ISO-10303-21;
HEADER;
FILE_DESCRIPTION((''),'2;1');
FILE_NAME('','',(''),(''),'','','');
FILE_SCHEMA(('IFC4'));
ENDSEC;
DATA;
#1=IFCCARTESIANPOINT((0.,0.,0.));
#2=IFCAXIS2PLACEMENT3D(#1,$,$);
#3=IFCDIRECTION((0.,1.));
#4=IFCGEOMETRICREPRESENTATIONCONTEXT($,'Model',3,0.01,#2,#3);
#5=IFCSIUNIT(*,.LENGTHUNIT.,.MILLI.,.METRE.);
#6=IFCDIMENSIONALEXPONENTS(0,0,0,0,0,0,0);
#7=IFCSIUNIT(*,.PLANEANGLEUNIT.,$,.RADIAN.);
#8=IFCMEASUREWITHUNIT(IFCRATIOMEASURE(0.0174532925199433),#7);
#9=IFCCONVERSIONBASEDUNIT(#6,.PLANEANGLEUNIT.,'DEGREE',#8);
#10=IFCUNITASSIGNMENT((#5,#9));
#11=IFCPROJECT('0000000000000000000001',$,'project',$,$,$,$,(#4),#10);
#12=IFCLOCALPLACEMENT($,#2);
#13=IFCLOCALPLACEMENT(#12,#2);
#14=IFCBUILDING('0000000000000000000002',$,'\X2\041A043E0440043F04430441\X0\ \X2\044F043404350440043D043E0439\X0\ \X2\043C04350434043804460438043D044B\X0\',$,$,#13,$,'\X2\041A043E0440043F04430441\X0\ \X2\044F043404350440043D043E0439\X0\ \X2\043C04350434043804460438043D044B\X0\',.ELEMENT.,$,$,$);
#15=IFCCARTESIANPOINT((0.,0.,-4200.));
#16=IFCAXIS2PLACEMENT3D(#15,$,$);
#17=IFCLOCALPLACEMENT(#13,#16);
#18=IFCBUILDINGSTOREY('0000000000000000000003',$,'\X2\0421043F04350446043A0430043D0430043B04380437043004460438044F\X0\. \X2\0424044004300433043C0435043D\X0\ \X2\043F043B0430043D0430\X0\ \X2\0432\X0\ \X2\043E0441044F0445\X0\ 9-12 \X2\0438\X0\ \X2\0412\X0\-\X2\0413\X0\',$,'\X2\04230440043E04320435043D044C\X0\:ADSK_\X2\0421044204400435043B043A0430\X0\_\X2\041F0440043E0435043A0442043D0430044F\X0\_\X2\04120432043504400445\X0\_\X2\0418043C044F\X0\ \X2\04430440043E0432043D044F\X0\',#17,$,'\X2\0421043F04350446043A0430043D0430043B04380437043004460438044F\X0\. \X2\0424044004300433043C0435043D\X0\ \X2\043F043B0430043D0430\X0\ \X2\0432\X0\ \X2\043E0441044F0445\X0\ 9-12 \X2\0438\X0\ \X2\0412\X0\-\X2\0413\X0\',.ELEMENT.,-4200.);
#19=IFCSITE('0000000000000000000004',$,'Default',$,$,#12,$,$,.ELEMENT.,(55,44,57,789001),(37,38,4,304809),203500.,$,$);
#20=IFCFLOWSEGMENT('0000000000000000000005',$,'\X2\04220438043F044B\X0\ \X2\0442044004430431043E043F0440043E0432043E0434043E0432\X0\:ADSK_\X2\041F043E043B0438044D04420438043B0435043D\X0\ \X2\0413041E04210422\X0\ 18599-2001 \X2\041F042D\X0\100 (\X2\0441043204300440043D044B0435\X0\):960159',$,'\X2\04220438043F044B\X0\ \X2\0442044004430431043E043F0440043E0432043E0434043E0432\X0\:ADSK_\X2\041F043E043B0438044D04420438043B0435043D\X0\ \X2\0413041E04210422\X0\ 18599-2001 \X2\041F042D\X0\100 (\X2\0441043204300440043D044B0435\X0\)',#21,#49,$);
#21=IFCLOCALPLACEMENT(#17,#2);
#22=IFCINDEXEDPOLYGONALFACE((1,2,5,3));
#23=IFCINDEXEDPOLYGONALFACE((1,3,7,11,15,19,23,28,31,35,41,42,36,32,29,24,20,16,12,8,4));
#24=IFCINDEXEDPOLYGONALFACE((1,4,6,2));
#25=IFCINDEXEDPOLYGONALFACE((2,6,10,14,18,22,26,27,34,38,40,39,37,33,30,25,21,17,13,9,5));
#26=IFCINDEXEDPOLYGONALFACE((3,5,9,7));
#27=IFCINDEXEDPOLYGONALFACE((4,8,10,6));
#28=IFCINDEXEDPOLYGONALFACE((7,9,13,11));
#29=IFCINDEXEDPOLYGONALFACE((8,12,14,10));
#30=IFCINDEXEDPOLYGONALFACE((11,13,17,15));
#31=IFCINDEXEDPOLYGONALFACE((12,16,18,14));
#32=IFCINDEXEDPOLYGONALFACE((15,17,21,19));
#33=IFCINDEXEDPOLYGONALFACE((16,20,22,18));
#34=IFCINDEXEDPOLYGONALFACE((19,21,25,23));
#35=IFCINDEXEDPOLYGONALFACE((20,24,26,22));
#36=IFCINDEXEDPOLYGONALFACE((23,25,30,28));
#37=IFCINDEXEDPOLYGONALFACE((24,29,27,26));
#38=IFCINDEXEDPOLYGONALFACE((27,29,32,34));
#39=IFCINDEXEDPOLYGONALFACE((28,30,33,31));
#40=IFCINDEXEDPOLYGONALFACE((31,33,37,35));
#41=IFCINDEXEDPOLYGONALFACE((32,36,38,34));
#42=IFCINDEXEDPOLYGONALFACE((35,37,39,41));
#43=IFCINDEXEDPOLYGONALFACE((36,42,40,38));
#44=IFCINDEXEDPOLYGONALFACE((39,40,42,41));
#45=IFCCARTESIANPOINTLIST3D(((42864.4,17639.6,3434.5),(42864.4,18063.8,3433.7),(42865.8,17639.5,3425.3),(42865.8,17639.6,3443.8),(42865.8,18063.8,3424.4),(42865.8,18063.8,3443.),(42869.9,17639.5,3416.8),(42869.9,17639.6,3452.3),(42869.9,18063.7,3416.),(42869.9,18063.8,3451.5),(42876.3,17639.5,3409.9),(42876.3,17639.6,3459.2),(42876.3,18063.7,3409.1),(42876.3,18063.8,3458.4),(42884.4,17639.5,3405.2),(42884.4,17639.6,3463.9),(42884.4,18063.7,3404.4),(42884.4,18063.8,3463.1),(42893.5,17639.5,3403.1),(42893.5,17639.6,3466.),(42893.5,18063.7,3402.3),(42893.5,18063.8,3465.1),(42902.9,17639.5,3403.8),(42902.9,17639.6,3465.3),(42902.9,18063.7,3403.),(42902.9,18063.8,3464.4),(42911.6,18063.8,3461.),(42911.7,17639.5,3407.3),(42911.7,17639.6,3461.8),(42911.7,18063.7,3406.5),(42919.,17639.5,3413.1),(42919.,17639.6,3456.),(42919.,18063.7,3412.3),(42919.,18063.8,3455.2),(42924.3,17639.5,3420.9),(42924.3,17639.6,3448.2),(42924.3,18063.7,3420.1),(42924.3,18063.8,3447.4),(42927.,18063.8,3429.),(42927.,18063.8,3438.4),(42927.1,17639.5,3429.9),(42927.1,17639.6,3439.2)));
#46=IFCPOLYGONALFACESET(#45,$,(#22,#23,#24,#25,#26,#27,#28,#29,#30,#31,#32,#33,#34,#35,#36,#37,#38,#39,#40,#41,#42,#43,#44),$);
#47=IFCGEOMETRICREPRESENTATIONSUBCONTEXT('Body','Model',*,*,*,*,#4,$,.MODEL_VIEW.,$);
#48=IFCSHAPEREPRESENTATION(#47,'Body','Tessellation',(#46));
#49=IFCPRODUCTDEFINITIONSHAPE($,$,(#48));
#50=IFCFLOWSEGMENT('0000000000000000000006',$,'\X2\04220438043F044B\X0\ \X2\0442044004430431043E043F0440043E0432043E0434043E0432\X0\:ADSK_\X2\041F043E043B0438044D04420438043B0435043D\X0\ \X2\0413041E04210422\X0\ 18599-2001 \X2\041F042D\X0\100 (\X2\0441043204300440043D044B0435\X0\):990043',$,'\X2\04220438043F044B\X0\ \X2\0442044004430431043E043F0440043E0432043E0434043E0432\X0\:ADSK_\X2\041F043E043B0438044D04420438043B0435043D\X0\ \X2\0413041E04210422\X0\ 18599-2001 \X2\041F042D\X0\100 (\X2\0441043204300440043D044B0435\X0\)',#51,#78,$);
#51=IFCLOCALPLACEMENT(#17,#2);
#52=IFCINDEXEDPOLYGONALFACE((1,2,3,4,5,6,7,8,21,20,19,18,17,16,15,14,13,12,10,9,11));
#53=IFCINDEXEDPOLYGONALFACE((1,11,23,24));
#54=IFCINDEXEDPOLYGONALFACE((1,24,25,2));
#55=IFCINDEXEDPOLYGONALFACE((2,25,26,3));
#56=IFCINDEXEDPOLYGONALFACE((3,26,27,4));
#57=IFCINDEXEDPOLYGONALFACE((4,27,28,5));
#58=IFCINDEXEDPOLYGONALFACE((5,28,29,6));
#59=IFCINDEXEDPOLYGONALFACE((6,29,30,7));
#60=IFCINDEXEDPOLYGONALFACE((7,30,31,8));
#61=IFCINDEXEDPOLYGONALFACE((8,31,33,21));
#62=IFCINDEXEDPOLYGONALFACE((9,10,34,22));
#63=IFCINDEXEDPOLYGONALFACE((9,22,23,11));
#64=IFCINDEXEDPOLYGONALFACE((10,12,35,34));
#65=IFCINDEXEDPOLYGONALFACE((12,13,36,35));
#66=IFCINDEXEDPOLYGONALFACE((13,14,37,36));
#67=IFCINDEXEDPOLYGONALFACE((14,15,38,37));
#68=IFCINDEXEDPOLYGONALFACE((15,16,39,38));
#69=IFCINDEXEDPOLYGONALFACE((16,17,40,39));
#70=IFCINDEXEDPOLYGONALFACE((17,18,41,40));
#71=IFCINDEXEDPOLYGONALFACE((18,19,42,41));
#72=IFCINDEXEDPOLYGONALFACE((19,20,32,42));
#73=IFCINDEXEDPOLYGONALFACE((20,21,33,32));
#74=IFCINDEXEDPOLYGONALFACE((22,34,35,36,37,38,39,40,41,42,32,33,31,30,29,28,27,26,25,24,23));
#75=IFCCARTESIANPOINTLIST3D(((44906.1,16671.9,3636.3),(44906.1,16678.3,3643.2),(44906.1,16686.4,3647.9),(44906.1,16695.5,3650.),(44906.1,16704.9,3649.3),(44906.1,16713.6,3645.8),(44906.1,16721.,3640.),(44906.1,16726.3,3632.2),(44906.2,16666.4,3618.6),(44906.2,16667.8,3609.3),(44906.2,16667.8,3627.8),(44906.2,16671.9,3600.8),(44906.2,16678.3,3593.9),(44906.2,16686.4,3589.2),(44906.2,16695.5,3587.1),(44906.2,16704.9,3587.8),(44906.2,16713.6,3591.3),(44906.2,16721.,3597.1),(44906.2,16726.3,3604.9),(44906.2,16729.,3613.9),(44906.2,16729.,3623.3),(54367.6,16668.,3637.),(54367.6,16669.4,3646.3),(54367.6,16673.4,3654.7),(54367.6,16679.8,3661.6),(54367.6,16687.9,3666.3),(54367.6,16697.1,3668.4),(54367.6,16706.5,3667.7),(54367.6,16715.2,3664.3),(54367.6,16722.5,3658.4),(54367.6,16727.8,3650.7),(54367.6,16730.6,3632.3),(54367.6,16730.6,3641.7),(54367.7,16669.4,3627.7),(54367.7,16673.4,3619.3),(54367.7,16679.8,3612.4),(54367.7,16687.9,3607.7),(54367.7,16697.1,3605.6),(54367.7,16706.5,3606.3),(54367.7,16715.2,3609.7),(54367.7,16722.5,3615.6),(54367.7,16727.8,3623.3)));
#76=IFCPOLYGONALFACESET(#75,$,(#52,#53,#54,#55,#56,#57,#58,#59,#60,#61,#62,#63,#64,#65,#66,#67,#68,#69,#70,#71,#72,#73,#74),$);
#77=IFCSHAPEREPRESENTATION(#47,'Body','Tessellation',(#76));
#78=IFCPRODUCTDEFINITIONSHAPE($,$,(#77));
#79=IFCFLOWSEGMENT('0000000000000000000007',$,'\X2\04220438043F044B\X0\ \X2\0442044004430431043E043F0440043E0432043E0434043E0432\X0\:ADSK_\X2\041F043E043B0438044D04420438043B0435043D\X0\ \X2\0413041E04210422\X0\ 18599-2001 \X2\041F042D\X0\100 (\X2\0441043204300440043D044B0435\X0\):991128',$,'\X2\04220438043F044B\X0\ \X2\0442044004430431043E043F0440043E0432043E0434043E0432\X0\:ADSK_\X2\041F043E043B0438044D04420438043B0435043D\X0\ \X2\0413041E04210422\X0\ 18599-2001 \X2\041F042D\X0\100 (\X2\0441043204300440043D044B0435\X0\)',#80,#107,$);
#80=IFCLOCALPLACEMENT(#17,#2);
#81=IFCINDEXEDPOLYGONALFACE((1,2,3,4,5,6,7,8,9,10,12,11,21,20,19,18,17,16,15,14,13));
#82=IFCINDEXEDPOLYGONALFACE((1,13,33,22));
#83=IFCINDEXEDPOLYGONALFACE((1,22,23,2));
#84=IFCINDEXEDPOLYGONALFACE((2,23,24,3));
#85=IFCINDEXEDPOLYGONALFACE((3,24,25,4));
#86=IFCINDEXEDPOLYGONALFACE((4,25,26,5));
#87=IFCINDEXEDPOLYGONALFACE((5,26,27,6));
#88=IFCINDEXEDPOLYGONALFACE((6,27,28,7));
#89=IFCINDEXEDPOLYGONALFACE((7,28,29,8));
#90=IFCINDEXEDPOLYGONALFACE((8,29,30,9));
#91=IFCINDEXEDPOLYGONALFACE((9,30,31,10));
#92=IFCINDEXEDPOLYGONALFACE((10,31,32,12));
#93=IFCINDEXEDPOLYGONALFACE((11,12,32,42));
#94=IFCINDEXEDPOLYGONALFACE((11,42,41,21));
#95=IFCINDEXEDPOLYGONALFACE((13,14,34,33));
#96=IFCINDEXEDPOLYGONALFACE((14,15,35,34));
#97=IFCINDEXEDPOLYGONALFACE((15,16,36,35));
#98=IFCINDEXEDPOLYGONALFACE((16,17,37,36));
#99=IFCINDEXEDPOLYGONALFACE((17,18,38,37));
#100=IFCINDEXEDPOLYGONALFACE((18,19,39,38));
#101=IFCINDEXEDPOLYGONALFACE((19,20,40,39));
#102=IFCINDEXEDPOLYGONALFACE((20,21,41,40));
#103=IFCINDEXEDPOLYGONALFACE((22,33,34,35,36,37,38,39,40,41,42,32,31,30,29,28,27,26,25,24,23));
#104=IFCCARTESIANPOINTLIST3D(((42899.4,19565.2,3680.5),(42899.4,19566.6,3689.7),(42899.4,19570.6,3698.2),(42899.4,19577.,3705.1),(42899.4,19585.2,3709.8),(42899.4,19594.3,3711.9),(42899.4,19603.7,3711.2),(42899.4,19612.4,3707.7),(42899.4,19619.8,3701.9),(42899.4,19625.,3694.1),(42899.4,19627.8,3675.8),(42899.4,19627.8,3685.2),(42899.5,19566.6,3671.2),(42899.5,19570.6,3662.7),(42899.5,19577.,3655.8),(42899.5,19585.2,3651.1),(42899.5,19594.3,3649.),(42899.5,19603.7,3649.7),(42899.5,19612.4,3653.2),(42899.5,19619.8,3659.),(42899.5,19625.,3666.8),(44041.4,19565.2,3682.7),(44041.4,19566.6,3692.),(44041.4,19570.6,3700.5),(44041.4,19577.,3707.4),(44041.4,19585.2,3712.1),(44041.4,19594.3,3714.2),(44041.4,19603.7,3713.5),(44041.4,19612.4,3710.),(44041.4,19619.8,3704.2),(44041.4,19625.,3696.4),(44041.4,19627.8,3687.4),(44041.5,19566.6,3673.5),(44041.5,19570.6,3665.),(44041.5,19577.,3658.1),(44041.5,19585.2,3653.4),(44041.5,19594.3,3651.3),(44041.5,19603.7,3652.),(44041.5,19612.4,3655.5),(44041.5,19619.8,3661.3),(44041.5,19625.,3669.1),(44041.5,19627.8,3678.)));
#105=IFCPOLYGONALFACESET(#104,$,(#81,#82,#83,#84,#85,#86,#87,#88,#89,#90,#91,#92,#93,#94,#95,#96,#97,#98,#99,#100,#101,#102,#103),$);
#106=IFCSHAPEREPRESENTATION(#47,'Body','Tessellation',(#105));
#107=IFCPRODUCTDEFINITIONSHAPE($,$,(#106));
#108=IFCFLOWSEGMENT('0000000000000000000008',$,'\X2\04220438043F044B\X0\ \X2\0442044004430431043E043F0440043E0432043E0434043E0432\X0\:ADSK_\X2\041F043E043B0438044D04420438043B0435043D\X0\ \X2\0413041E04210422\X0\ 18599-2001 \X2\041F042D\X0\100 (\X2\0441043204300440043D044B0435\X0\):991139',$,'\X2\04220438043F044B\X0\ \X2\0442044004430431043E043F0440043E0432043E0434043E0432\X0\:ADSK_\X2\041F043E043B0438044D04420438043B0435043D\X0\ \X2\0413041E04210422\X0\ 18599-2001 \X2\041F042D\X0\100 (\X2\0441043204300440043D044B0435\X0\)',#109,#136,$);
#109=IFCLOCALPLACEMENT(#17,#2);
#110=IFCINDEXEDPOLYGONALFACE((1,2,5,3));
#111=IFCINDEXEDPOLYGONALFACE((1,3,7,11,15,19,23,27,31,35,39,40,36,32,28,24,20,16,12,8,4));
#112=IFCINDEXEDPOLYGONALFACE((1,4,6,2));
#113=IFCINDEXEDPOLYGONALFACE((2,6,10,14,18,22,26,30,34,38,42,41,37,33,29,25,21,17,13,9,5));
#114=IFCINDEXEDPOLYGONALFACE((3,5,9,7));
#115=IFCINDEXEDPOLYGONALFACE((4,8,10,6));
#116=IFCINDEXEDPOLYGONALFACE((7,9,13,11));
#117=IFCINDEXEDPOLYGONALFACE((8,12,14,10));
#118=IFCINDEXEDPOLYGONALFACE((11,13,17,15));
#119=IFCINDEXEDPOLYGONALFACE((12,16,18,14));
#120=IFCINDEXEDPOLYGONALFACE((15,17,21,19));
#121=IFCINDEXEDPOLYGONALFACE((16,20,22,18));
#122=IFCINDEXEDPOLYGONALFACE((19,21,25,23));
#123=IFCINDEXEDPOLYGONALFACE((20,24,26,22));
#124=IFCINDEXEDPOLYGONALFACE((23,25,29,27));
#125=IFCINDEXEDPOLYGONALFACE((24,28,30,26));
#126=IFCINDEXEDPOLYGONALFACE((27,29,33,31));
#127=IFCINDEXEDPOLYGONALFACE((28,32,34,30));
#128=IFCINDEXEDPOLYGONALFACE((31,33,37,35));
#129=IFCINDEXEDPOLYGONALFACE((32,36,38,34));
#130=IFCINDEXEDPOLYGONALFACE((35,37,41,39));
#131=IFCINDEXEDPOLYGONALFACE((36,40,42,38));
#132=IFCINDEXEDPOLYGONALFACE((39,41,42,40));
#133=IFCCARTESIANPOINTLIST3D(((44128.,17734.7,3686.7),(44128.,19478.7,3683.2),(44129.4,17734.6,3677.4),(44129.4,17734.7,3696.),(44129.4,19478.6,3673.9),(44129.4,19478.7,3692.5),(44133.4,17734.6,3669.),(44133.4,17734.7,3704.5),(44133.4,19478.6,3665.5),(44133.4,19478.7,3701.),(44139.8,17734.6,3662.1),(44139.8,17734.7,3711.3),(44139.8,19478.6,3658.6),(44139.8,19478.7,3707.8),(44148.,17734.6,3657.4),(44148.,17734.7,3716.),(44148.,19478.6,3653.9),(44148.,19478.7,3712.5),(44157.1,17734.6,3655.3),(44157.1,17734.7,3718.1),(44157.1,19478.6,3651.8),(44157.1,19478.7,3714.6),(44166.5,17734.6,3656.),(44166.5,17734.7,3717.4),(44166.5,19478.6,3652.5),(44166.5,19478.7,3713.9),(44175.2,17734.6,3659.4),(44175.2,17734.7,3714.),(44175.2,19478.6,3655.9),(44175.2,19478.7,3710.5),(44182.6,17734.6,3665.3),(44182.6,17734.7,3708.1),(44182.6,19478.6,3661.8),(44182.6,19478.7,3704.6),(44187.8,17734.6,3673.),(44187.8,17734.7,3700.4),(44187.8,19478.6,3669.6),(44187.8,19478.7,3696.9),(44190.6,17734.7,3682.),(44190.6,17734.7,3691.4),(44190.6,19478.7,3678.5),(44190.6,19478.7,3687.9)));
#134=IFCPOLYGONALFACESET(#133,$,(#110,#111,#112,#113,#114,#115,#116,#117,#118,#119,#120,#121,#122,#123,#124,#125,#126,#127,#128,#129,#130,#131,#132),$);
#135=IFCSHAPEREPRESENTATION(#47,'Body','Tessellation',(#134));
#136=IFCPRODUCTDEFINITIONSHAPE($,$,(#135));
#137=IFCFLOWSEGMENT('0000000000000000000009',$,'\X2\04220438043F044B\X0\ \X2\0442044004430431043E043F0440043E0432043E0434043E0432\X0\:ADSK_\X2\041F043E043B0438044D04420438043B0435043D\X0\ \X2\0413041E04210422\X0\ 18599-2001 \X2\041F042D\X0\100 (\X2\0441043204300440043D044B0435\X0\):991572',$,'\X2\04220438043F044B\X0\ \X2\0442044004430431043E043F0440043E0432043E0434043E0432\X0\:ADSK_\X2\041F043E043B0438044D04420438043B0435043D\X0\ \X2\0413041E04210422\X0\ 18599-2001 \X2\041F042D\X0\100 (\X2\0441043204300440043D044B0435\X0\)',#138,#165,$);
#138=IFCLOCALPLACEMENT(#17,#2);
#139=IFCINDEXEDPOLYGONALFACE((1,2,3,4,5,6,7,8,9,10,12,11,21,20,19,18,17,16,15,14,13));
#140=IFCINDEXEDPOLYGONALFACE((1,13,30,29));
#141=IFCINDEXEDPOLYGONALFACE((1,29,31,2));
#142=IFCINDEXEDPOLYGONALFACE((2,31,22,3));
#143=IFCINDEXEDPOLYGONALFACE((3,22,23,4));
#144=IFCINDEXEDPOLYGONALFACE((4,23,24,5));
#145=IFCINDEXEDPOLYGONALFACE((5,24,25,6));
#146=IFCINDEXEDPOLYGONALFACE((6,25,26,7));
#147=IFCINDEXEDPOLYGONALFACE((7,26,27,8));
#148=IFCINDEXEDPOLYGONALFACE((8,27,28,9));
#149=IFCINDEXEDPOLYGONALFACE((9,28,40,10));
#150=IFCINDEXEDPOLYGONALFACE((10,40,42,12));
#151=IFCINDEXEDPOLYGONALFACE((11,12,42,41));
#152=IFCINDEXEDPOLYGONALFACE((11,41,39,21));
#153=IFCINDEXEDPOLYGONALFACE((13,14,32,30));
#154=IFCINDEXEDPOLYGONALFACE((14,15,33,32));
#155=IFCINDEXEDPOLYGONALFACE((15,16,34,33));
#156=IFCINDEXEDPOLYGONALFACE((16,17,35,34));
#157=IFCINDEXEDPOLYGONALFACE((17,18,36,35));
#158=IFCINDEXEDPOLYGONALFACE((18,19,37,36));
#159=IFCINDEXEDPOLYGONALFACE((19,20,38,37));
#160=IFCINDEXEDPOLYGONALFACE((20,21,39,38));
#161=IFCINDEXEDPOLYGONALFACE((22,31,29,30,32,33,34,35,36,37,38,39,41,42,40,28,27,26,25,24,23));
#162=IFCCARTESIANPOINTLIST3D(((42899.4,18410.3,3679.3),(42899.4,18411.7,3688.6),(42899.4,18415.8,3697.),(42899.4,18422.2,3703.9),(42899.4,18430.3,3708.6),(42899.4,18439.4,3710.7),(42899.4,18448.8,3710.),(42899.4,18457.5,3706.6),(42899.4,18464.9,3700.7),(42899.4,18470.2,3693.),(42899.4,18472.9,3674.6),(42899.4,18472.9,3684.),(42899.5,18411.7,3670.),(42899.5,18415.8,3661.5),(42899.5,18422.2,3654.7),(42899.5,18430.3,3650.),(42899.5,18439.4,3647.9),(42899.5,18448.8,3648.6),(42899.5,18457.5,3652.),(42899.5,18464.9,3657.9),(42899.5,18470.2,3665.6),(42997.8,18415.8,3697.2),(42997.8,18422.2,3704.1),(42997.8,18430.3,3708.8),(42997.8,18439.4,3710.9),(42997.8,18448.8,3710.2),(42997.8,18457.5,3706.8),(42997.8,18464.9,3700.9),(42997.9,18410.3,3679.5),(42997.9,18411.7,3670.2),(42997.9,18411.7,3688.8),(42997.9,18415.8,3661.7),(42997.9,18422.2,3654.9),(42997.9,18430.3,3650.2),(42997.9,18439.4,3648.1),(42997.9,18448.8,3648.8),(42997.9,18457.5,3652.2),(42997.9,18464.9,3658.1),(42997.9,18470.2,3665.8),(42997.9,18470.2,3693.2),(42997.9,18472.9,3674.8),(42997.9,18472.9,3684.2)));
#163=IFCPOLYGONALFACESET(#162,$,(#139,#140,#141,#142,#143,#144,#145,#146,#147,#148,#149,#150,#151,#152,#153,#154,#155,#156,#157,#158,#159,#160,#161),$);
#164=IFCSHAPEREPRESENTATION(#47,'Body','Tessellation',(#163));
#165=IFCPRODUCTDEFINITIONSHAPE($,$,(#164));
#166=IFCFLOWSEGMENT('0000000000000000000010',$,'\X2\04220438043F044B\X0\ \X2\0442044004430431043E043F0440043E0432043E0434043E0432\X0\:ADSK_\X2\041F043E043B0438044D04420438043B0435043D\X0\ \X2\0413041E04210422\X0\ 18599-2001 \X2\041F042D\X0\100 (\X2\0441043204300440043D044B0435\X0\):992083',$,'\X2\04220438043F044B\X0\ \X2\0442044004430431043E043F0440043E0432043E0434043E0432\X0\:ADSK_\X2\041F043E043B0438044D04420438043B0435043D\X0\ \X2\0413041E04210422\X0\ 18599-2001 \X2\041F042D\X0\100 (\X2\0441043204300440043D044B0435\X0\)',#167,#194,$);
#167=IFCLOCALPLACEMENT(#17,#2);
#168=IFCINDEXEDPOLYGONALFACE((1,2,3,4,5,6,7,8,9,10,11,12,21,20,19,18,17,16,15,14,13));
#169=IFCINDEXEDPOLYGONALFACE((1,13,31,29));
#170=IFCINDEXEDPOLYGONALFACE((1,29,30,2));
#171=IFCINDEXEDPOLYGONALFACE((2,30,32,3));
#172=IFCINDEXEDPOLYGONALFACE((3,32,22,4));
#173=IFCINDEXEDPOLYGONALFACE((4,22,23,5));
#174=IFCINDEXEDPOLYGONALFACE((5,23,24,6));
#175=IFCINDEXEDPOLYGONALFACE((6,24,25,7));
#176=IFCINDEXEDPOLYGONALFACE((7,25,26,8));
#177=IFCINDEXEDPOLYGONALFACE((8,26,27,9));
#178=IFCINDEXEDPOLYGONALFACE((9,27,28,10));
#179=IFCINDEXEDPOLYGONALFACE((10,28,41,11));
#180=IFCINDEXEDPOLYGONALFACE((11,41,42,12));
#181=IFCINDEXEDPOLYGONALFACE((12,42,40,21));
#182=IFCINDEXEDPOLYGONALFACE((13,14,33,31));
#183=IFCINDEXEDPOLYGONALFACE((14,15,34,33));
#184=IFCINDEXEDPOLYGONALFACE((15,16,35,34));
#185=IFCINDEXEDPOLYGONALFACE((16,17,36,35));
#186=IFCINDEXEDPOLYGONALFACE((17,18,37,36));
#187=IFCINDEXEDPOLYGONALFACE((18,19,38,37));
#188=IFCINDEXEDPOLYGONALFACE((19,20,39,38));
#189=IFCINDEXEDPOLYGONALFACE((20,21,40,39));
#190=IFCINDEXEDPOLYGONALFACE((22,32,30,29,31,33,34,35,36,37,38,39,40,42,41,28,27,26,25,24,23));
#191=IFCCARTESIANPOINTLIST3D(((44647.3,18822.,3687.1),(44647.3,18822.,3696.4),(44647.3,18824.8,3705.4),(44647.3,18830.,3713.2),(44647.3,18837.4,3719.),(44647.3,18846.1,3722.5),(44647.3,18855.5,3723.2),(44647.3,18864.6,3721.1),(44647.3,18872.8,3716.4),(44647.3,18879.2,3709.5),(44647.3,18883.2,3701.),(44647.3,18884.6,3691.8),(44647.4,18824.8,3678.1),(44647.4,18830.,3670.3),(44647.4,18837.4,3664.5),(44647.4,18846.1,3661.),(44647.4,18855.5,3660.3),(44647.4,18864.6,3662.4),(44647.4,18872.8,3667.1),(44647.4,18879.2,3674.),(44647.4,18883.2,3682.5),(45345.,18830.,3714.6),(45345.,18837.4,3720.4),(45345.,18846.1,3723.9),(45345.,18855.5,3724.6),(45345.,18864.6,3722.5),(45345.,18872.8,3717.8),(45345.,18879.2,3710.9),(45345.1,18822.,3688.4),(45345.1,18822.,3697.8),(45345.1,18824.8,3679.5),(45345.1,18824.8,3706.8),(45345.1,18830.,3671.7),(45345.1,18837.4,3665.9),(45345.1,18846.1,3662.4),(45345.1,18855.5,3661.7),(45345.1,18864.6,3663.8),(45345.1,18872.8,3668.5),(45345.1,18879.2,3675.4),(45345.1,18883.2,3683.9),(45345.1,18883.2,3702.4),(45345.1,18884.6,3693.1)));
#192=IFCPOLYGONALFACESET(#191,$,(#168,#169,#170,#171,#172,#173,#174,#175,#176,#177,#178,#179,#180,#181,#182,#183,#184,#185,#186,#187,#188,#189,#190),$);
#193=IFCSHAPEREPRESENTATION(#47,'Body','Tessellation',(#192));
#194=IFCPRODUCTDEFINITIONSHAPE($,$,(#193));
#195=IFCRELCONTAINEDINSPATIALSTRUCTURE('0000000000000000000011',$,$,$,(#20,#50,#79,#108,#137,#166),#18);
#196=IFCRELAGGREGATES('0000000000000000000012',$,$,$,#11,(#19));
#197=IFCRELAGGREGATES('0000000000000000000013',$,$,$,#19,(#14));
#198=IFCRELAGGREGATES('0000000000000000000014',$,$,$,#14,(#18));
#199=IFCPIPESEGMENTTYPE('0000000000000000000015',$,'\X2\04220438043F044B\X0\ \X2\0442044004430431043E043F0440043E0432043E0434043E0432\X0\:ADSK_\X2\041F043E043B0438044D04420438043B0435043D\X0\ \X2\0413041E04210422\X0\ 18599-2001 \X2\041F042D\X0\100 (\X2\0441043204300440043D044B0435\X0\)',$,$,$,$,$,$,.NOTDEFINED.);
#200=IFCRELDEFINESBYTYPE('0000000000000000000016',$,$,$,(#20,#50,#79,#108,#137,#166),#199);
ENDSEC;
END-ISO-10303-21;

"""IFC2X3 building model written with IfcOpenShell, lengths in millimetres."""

from ifc_helpers import new_model, entity, si_unit, converted_unit, direction, frame, origin, origin_2d_with_axis, place, context, subcontext, project, spatial, circle, extrude, type_object, element, save


model = new_model("IFC2X3")

# Units and contexts
model_context = context("Model", 3, precision=0.01, world=origin(), true_north=direction((0.0, 1.0)))
body_context = subcontext(model_context, "Body", "Model", "MODEL_VIEW")
ifc_project = project(units=[si_unit("LENGTHUNIT", "METRE", prefix="MILLI"), converted_unit("PLANEANGLEUNIT", "DEGREE", entity("IfcRatioMeasure", 0.0174532925199433), si_unit("PLANEANGLEUNIT", "RADIAN"), dimensions=[0, 0, 0, 0, 0, 0, 0])], contexts=[model_context])

# Site, building, storey
site_placement = place(None, origin())
site = spatial("IfcSite", under=ifc_project, at=site_placement, Name="Default", CompositionType="ELEMENT", RefLatitude=(55, 44, 57, 789001), RefLongitude=(37, 38, 4, 304809), RefElevation=203500.0)
building_placement = place(site_placement, origin())
building = spatial("IfcBuilding", under=site, at=building_placement, Name="Корпус ядерной медицины", LongName="Корпус ядерной медицины", CompositionType="ELEMENT")
storey_placement = place(building_placement, frame((0.0, 0.0, -4200.0)))
storey = spatial("IfcBuildingStorey", under=building, at=storey_placement, Name="Спецканализация. Фрагмен плана в осях 9-12 и В-Г", ObjectType="Уровень:ADSK_Стрелка_Проектная_Вверх_Имя уровня", LongName="Спецканализация. Фрагмен плана в осях 9-12 и В-Г", CompositionType="ELEMENT", Elevation=-4200.0)

# Flow segments
pipe_segment_type = type_object("IfcPipeSegmentType", Name="Типы трубопроводов:ADSK_Полиэтилен ГОСТ 18599-2001 ПЭ100 (сварные)", PredefinedType="NOTDEFINED")
flow_segment_1_placement = place(storey_placement, frame((42862.8, 17639.5, 3400.6)))
element("IfcFlowSegment", 1, at=flow_segment_1_placement, inside=storey, type_object=pipe_segment_type, Name="Типы трубопроводов:ADSK_Полиэтилен ГОСТ 18599-2001 ПЭ100 (сварные):960159", ObjectType="Типы трубопроводов:ADSK_Полиэтилен ГОСТ 18599-2001 ПЭ100 (сварные)", context=body_context, shape_type="SweptSolid", body=[
    extrude(circle(Radius=31.5, at=origin_2d_with_axis()), frame((33.1, 424.3, 33.1), z_axis=(0.000009, -0.999998, 0.001929), x_axis=(-1.0, -0.000009, 0.0)), (0.0, 0.0, 1.0), 424.2),
])
flow_segment_2_placement = place(storey_placement, frame((44906.1, 16664.8, 3585.5)))
element("IfcFlowSegment", 2, at=flow_segment_2_placement, inside=storey, type_object=pipe_segment_type, Name="Типы трубопроводов:ADSK_Полиэтилен ГОСТ 18599-2001 ПЭ100 (сварные):990043", ObjectType="Типы трубопроводов:ADSK_Полиэтилен ГОСТ 18599-2001 ПЭ100 (сварные)", context=body_context, shape_type="SweptSolid", body=[
    extrude(circle(Radius=31.5, at=origin_2d_with_axis()), frame((0.1, 33.1, 33.1), z_axis=(0.999998, 0.000166, 0.001949), x_axis=(0.000166, -1.0, 0.0)), (0.0, 0.0, 1.0), 9461.5),
])
flow_segment_3_placement = place(storey_placement, frame((42899.4, 19563.6, 3647.4)))
element("IfcFlowSegment", 3, at=flow_segment_3_placement, inside=storey, type_object=pipe_segment_type, Name="Типы трубопроводов:ADSK_Полиэтилен ГОСТ 18599-2001 ПЭ100 (сварные):991128", ObjectType="Типы трубопроводов:ADSK_Полиэтилен ГОСТ 18599-2001 ПЭ100 (сварные)", context=body_context, shape_type="SweptSolid", body=[
    extrude(circle(Radius=31.5, at=origin_2d_with_axis()), frame((0.1, 33.1, 33.1), z_axis=(0.999998, 0.0, 0.002), x_axis=(0.0, -1.0, 0.0)), (0.0, 0.0, 1.0), 1142.0),
])
flow_segment_4_placement = place(storey_placement, frame((44126.4, 17734.6, 3650.1)))
element("IfcFlowSegment", 4, at=flow_segment_4_placement, inside=storey, type_object=pipe_segment_type, Name="Типы трубопроводов:ADSK_Полиэтилен ГОСТ 18599-2001 ПЭ100 (сварные):991139", ObjectType="Типы трубопроводов:ADSK_Полиэтилен ГОСТ 18599-2001 ПЭ100 (сварные)", context=body_context, shape_type="SweptSolid", body=[
    extrude(circle(Radius=31.5, at=origin_2d_with_axis()), frame((33.1, 1744.1, 33.1), z_axis=(0.0, -0.999998, 0.002), x_axis=(-1.0, 0.0, 0.0)), (0.0, 0.0, 1.0), 1744.0),
])
flow_segment_5_placement = place(storey_placement, frame((42899.4, 18408.7, 3646.2)))
element("IfcFlowSegment", 5, at=flow_segment_5_placement, inside=storey, type_object=pipe_segment_type, Name="Типы трубопроводов:ADSK_Полиэтилен ГОСТ 18599-2001 ПЭ100 (сварные):991572", ObjectType="Типы трубопроводов:ADSK_Полиэтилен ГОСТ 18599-2001 ПЭ100 (сварные)", context=body_context, shape_type="SweptSolid", body=[
    extrude(circle(Radius=31.5, at=origin_2d_with_axis()), frame((0.1, 33.1, 33.1), z_axis=(0.999998, 0.0, 0.001997), x_axis=(0.0, -1.0, 0.0)), (0.0, 0.0, 1.0), 98.4),
])
flow_segment_6_placement = place(storey_placement, frame((44647.3, 18820.0, 3658.7)))
element("IfcFlowSegment", 6, at=flow_segment_6_placement, inside=storey, type_object=pipe_segment_type, Name="Типы трубопроводов:ADSK_Полиэтилен ГОСТ 18599-2001 ПЭ100 (сварные):992083", ObjectType="Типы трубопроводов:ADSK_Полиэтилен ГОСТ 18599-2001 ПЭ100 (сварные)", context=body_context, shape_type="SweptSolid", body=[
    extrude(circle(Radius=31.5, at=origin_2d_with_axis()), frame((0.1, 33.1, 33.1), z_axis=(0.999998, -0.000001, 0.001995), x_axis=(0.000001, 1.0, 0.0)), (0.0, 0.0, 1.0), 697.7),
])

save(model, "model.ifc")
